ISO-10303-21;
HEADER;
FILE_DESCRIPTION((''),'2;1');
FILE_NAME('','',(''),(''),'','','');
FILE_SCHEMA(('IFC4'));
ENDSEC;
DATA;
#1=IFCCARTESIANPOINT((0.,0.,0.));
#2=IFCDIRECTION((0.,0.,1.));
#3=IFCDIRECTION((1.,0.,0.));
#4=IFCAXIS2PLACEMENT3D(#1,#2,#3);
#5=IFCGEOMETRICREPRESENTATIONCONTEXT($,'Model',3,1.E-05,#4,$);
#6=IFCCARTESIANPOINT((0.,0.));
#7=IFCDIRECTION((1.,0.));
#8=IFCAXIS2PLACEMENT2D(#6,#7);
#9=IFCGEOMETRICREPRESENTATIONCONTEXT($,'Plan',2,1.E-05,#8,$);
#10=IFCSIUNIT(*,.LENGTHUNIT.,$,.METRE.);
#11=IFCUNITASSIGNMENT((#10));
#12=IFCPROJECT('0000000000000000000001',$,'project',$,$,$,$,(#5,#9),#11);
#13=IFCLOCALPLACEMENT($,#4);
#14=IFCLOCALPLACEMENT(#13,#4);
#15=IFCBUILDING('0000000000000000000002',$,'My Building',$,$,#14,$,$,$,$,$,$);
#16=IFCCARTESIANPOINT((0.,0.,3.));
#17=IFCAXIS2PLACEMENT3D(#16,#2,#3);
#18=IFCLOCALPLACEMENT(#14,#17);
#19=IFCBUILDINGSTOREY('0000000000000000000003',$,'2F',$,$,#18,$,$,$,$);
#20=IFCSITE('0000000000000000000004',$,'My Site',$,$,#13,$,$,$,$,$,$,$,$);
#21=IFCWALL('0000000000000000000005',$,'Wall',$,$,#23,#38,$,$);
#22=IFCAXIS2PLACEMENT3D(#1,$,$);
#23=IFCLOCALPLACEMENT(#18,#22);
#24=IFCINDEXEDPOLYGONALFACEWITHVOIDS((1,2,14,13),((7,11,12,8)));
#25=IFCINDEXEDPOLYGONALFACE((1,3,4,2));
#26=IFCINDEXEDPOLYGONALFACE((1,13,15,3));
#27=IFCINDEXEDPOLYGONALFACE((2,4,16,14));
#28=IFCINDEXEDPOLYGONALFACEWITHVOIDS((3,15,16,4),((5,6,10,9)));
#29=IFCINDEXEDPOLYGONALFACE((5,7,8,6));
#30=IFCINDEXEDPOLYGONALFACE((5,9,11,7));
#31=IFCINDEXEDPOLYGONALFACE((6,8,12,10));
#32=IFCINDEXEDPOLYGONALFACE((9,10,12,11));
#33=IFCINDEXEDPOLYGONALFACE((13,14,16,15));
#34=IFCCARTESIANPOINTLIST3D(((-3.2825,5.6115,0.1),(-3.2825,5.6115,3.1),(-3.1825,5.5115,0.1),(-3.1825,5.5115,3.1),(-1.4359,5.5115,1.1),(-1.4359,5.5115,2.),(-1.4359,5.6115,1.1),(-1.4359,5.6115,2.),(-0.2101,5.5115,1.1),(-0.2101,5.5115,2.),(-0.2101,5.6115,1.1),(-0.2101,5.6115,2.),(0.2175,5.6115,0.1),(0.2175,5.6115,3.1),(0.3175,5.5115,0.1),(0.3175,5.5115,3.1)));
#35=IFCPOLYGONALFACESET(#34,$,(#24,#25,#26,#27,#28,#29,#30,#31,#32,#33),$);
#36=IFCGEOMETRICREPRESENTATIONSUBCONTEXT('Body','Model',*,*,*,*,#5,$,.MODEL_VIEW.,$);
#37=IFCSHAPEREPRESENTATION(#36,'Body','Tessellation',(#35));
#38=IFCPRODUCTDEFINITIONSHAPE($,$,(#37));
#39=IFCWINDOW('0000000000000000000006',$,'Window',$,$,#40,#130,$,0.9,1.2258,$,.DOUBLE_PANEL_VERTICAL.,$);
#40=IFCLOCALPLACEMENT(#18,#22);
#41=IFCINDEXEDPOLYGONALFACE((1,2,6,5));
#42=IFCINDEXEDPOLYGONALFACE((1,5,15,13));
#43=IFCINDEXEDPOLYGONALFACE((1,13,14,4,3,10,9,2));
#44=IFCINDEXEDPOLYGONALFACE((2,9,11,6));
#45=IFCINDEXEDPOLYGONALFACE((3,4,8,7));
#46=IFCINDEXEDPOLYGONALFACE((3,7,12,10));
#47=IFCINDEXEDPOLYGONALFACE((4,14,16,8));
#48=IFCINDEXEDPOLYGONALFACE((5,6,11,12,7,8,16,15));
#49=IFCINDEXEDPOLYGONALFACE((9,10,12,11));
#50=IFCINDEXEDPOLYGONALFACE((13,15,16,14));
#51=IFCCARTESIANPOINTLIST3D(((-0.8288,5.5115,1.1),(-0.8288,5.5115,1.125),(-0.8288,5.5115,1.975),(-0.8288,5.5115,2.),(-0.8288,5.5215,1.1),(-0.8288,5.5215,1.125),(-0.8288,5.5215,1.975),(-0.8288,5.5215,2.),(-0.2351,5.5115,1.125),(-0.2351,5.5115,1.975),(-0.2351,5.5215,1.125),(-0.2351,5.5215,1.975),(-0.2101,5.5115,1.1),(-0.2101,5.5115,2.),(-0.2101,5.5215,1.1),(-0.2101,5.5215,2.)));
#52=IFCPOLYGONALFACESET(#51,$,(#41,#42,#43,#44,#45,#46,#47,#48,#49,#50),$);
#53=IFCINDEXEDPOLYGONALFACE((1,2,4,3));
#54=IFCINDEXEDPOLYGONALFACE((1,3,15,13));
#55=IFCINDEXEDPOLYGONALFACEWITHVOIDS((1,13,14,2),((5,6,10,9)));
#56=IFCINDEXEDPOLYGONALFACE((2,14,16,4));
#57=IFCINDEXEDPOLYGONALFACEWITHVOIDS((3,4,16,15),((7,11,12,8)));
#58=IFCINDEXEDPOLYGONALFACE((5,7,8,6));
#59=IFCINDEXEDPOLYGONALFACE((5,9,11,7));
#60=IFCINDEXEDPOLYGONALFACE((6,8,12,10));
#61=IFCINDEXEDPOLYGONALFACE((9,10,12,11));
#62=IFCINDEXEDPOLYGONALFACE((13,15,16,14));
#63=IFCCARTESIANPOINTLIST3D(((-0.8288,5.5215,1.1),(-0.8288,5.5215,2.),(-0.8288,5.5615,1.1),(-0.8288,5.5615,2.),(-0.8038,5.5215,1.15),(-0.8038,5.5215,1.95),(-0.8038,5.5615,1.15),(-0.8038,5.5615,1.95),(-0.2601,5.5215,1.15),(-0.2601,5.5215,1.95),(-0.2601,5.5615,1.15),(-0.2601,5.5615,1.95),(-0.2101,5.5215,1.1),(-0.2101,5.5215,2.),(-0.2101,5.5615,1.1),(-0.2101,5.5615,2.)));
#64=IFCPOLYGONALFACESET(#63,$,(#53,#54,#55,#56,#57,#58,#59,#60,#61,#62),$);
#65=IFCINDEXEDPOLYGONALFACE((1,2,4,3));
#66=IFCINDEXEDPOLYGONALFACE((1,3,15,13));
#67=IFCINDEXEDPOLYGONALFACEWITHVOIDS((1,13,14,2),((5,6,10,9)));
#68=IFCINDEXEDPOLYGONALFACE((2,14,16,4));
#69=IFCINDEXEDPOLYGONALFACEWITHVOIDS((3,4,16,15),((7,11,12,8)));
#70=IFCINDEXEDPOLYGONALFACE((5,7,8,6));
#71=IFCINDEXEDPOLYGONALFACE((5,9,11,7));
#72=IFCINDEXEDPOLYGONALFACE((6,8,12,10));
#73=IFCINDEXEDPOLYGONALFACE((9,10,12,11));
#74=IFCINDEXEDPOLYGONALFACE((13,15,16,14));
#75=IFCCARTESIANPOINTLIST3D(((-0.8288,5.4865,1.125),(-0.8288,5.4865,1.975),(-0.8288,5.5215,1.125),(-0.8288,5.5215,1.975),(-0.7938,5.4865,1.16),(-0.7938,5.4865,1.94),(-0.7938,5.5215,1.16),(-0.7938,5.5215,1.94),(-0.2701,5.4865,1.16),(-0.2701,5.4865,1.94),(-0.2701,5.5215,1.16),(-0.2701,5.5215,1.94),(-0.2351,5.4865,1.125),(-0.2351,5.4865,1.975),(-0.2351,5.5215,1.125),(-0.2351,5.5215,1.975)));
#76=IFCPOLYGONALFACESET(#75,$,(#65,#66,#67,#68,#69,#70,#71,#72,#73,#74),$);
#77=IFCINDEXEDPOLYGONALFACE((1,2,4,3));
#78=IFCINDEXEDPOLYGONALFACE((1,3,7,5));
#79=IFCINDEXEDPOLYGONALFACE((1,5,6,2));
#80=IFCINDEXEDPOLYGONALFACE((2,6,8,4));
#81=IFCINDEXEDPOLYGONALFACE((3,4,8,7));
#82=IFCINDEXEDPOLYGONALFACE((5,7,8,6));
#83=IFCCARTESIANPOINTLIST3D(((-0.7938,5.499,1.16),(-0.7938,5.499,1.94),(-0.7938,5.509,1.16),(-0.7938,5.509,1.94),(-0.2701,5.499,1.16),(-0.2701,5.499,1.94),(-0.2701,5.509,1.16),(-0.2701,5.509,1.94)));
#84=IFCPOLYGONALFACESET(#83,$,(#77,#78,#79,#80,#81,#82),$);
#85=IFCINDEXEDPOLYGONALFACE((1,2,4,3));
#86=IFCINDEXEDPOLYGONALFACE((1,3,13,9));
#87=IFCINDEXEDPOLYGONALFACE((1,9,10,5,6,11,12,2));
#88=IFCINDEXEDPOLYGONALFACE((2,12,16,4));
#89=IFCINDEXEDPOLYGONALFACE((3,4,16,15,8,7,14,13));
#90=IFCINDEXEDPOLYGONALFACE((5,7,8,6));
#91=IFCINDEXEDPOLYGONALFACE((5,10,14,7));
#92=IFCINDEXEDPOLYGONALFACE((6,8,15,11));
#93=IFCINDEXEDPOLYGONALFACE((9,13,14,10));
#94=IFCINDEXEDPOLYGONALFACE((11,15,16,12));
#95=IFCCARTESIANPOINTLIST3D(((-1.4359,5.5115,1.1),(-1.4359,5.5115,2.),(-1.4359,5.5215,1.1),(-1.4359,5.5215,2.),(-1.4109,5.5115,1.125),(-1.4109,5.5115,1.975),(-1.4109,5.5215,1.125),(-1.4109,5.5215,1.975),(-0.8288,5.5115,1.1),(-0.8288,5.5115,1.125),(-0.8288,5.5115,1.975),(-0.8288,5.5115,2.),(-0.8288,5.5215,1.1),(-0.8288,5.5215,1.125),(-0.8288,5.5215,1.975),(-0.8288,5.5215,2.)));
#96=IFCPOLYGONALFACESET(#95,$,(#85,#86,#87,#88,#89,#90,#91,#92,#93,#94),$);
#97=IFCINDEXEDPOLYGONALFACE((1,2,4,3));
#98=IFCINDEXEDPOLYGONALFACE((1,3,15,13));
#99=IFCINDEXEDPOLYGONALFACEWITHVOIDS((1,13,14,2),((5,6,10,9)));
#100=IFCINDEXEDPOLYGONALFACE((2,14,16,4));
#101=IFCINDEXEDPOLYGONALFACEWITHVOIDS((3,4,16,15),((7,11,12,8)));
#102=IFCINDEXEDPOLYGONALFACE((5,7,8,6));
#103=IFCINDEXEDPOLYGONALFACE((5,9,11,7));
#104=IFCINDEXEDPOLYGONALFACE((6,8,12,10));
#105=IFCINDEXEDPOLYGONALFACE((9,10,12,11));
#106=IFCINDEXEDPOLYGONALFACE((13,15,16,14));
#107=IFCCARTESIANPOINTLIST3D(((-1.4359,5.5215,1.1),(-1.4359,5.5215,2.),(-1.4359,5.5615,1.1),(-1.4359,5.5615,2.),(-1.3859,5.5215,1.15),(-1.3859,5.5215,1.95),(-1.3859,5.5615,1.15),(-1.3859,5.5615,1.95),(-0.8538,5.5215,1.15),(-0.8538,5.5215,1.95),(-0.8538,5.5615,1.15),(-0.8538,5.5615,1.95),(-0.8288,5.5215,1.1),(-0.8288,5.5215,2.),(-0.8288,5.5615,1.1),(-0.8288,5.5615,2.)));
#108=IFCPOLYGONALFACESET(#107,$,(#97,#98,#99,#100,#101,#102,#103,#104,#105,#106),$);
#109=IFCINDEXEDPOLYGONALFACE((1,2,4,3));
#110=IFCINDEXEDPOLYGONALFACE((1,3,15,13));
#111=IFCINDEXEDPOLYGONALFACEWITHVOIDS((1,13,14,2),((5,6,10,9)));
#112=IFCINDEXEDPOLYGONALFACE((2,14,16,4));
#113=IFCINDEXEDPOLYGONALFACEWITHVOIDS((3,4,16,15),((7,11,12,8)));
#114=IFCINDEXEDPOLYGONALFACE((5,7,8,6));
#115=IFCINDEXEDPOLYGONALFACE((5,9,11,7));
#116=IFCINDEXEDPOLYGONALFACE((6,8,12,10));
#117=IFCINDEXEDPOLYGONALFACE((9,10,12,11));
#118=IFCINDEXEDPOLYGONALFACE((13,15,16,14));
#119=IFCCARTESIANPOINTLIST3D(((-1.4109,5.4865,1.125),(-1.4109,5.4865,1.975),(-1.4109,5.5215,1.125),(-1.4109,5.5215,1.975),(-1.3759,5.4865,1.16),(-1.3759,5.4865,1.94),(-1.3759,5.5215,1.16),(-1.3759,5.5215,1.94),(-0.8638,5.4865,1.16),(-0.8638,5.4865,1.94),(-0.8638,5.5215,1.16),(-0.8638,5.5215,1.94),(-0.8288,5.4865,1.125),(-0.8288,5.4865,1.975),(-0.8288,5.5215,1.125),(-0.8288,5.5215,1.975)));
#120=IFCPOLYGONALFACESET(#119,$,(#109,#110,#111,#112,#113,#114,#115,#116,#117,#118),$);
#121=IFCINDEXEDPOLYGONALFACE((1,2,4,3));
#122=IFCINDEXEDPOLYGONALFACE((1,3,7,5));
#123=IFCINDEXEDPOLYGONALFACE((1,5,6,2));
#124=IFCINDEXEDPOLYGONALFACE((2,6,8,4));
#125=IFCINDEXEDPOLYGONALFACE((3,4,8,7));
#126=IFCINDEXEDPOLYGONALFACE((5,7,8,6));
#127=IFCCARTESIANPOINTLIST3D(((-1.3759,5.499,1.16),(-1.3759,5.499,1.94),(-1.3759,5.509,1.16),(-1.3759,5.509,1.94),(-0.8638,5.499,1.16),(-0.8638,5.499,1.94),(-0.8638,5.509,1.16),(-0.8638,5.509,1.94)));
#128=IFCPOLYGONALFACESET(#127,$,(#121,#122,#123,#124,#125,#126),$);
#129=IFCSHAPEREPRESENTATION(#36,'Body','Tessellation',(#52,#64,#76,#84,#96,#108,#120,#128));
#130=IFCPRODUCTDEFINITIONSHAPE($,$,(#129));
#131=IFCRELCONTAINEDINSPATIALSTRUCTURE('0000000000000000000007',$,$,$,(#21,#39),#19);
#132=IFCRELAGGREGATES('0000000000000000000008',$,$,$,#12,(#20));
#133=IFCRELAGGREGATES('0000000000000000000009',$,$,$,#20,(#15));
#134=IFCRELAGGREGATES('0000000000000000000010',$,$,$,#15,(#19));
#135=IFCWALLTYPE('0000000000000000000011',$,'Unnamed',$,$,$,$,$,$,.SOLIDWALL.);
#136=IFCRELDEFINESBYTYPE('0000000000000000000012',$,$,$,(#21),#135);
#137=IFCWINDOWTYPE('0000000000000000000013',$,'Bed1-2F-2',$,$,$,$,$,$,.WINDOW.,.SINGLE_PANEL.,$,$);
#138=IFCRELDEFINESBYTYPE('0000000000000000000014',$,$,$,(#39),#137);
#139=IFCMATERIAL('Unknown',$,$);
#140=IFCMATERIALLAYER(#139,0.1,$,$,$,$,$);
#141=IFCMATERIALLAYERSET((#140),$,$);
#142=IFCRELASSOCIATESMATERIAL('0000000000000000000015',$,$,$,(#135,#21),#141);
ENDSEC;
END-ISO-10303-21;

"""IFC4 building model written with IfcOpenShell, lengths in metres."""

from ifc_helpers import new_model, entity, si_unit, frame, origin_with_axes, origin_2d_with_axis, place, context, subcontext, project, spatial, line, indexed_curve, outline, extrude, shape, source, transform, mapped, material, layer, layer_set, layer_usage, type_object, type_shapes, element, fill, save


model = new_model("IFC4")

# Units and contexts
model_context = context("Model", 3, precision=1e-05, world=origin_with_axes())
plan_context = context("Plan", 2, precision=1e-05, world=origin_2d_with_axis())
body_context_1 = subcontext(model_context, "Body", "Model", "MODEL_VIEW")
body_context_2 = subcontext(plan_context, "Body", "Plan", "PLAN_VIEW")
ifc_project = project(units=[si_unit("LENGTHUNIT", "METRE")], contexts=[model_context, plan_context])

# Site, building, storey
site_placement = place(None, origin_with_axes())
site = spatial("IfcSite", under=ifc_project, at=site_placement, Name="My Site")
building_placement = place(site_placement, origin_with_axes())
building = spatial("IfcBuilding", under=site, at=building_placement, Name="My Building")
storey_placement = place(building_placement, frame((0.0, 0.0, 3.0), z_axis=(0.0, 0.0, 1.0), x_axis=(1.0, 0.0, 0.0)))
storey = spatial("IfcBuildingStorey", under=building, at=storey_placement, Name="2F")

# Shared definitions
ifc_material = material(Name="Unknown")

# Shared definitions
ifc_layer_1 = layer(ifc_material, 0.1)
ifc_layer_set_1 = layer_set([ifc_layer_1])
wall_type = type_object("IfcWallType", Name="Unnamed", PredefinedType="SOLIDWALL", material=ifc_layer_set_1)

# Wall, opening, window
ifc_layer_usage_1 = layer_usage(ifc_layer_set_1, "AXIS2", "POSITIVE", 0.0)
wall_1_placement = place(storey_placement, frame((-3.1825, 5.5115, 0.1), z_axis=(0.0, 0.0, 1.0), x_axis=(1.0, 0.0, 0.0)))
wall_1 = element("IfcWall", 1, at=wall_1_placement, inside=storey, type_object=wall_type, material=ifc_layer_usage_1, Name="Wall", context=body_context_1, shape_type="SweptSolid", body=[
    extrude(outline(indexed_curve([(0.0, 0.0), (-0.1, 0.1), (3.4, 0.1), (3.5, 0.0)], segments=[line(1, 2, 3, 4, 1)])), origin_with_axes(), (0.0, 0.0, 1.0), 3.0),
])
shared_shape_1 = source(origin_with_axes(), body_context_1, "Body", "SweptSolid", [
    extrude(outline(indexed_curve([(0.0, 0.0), (1.2258, 0.0), (1.2258, 0.9), (0.0, 0.9)], segments=[line(1, 2, 3, 4, 1)])), frame((0.0, -0.6, 0.0), z_axis=(0.0, -1.0, 0.0), x_axis=(1.0, 0.0, 0.0)), (0.0, 0.0, -1.0), 1.2),
])
opening_1_placement = place(wall_1_placement, frame((2.9724, 0.1, 1.0), z_axis=(0.0, 0.0, 1.0), x_axis=(-1.0, 0.0, 0.0)))
opening_1 = element("IfcOpeningElement", 2, at=opening_1_placement, cuts=wall_1, PredefinedType="OPENING", context=body_context_1, shape_type="MappedRepresentation", body=[
    mapped(shared_shape_1, transform((0.0, 0.0, 0.0), x_axis=(1.0, 0.0, 0.0), y_axis=(0.0, 1.0, 0.0), z_axis=(0.0, 0.0, 1.0), scale=1.0)),
])
window_type_1 = type_object("IfcWindowType", Name="Bed1-2F-2", PartitioningType="SINGLE_PANEL", PredefinedType="WINDOW")
shared_shape_2 = source(origin_with_axes(), body_context_1, "Body", "SweptSolid", [
    extrude(outline(indexed_curve([(0.6187, 0.0), (0.0, 0.0), (0.0, 0.9), (0.6187, 0.9), (0.6187, 0.875), (0.025, 0.875), (0.025, 0.025), (0.6187, 0.025)], segments=[line(1, 2, 3, 4, 5, 6, 7, 8, 1)])), frame((0.0, 0.09, 0.0), z_axis=(0.0, -1.0, 0.0), x_axis=(1.0, 0.0, 0.0)), (0.0, 0.0, -1.0), 0.01),
    extrude(outline(indexed_curve([(0.0, 0.0), (0.6187, 0.0), (0.6187, 0.9), (0.0, 0.9)], segments=[line(1, 2, 3, 4, 1)]), holes=[indexed_curve([(0.05, 0.05), (0.5937, 0.05), (0.5937, 0.85), (0.05, 0.85)], segments=[line(1, 2, 3, 4, 1)])]), frame((0.0, 0.05, 0.0), z_axis=(0.0, -1.0, 0.0), x_axis=(1.0, 0.0, 0.0)), (0.0, 0.0, -1.0), 0.04),
    extrude(outline(indexed_curve([(0.0, 0.0), (0.5937, 0.0), (0.5937, 0.85), (0.0, 0.85)], segments=[line(1, 2, 3, 4, 1)]), holes=[indexed_curve([(0.035, 0.035), (0.5587, 0.035), (0.5587, 0.815), (0.035, 0.815)], segments=[line(1, 2, 3, 4, 1)])]), frame((0.025, 0.09, 0.025), z_axis=(0.0, -1.0, 0.0), x_axis=(1.0, 0.0, 0.0)), (0.0, 0.0, -1.0), 0.035),
    extrude(outline(indexed_curve([(0.035, 0.035), (0.5587, 0.035), (0.5587, 0.815), (0.035, 0.815)], segments=[line(1, 2, 3, 4, 1)])), frame((0.025, 0.1025, 0.025), z_axis=(0.0, -1.0, 0.0), x_axis=(1.0, 0.0, 0.0)), (0.0, 0.0, -1.0), 0.01),
    extrude(outline(indexed_curve([(0.0, 0.9), (0.6071, 0.9), (0.6071, 0.0), (0.0, 0.0), (0.0, 0.025), (0.5821, 0.025), (0.5821, 0.875), (0.0, 0.875)], segments=[line(1, 2, 3, 4, 5, 6, 7, 8, 1)])), frame((0.6187, 0.09, 0.0), z_axis=(0.0, -1.0, 0.0), x_axis=(1.0, 0.0, 0.0)), (0.0, 0.0, -1.0), 0.01),
    extrude(outline(indexed_curve([(0.0, 0.0), (0.6071, 0.0), (0.6071, 0.9), (0.0, 0.9)], segments=[line(1, 2, 3, 4, 1)]), holes=[indexed_curve([(0.025, 0.05), (0.5571, 0.05), (0.5571, 0.85), (0.025, 0.85)], segments=[line(1, 2, 3, 4, 1)])]), frame((0.6187, 0.05, 0.0), z_axis=(0.0, -1.0, 0.0), x_axis=(1.0, 0.0, 0.0)), (0.0, 0.0, -1.0), 0.04),
    extrude(outline(indexed_curve([(0.0, 0.0), (0.5821, 0.0), (0.5821, 0.85), (0.0, 0.85)], segments=[line(1, 2, 3, 4, 1)]), holes=[indexed_curve([(0.035, 0.035), (0.5471, 0.035), (0.5471, 0.815), (0.035, 0.815)], segments=[line(1, 2, 3, 4, 1)])]), frame((0.6187, 0.09, 0.025), z_axis=(0.0, -1.0, 0.0), x_axis=(1.0, 0.0, 0.0)), (0.0, 0.0, -1.0), 0.035),
    extrude(outline(indexed_curve([(0.035, 0.035), (0.5471, 0.035), (0.5471, 0.815), (0.035, 0.815)], segments=[line(1, 2, 3, 4, 1)])), frame((0.6187, 0.1025, 0.025), z_axis=(0.0, -1.0, 0.0), x_axis=(1.0, 0.0, 0.0)), (0.0, 0.0, -1.0), 0.01),
])
shared_shape_3 = source(origin_with_axes(), body_context_2, "Body", "Curve2D", [
    entity("IfcIndexedPolyCurve", entity("IfcCartesianPointList2D", [[0.05, 0.05], [0.5937, 0.05]])),
    entity("IfcIndexedPolyCurve", entity("IfcCartesianPointList2D", [[0.0, 0.1], [0.025, 0.1], [0.025, 0.09], [0.05, 0.09], [0.05, 0.05], [0.0, 0.05]]), [entity("IfcLineIndex", [1, 2, 3, 4, 5, 6, 1])]),
    entity("IfcIndexedPolyCurve", entity("IfcCartesianPointList2D", [[0.6187, 0.1], [0.6187, 0.1], [0.6187, 0.09], [0.5937, 0.09], [0.5937, 0.05], [0.6187, 0.05]])),
    entity("IfcIndexedPolyCurve", entity("IfcCartesianPointList2D", [[0.025, 0.09], [0.06, 0.09], [0.06, 0.125], [0.025, 0.125]]), [entity("IfcLineIndex", [1, 2, 3, 4, 1])]),
    entity("IfcIndexedPolyCurve", entity("IfcCartesianPointList2D", [[0.6187, 0.09], [0.5837, 0.09], [0.5837, 0.125], [0.6187, 0.125]]), [entity("IfcLineIndex", [1, 2, 3, 4, 1])]),
    entity("IfcIndexedPolyCurve", entity("IfcCartesianPointList2D", [[0.06, 0.09], [0.5837, 0.09]])),
    entity("IfcIndexedPolyCurve", entity("IfcCartesianPointList2D", [[0.06, 0.125], [0.5837, 0.125]])),
    entity("IfcIndexedPolyCurve", entity("IfcCartesianPointList2D", [[0.06, 0.1075], [0.5837, 0.1075]])),
    entity("IfcIndexedPolyCurve", entity("IfcCartesianPointList2D", [[0.6437, 0.05], [1.1758, 0.05]])),
    entity("IfcIndexedPolyCurve", entity("IfcCartesianPointList2D", [[0.6187, 0.1], [0.6187, 0.1], [0.6187, 0.09], [0.6437, 0.09], [0.6437, 0.05], [0.6187, 0.05]])),
    entity("IfcIndexedPolyCurve", entity("IfcCartesianPointList2D", [[1.2258, 0.1], [1.2008, 0.1], [1.2008, 0.09], [1.1758, 0.09], [1.1758, 0.05], [1.2258, 0.05]]), [entity("IfcLineIndex", [1, 2, 3, 4, 5, 6, 1])]),
    entity("IfcIndexedPolyCurve", entity("IfcCartesianPointList2D", [[0.6187, 0.09], [0.6537, 0.09], [0.6537, 0.125], [0.6187, 0.125]]), [entity("IfcLineIndex", [1, 2, 3, 4, 1])]),
    entity("IfcIndexedPolyCurve", entity("IfcCartesianPointList2D", [[1.2008, 0.09], [1.1658, 0.09], [1.1658, 0.125], [1.2008, 0.125]]), [entity("IfcLineIndex", [1, 2, 3, 4, 1])]),
    entity("IfcIndexedPolyCurve", entity("IfcCartesianPointList2D", [[0.6537, 0.09], [1.1658, 0.09]])),
    entity("IfcIndexedPolyCurve", entity("IfcCartesianPointList2D", [[0.6537, 0.125], [1.1658, 0.125]])),
    entity("IfcIndexedPolyCurve", entity("IfcCartesianPointList2D", [[0.6537, 0.1075], [1.1658, 0.1075]])),
])
type_shapes(window_type_1, [shared_shape_2, shared_shape_3])
window_1_placement = place(opening_1_placement, frame((0.0, 0.0, 0.0), z_axis=(0.0, 0.0, 1.0), x_axis=(1.0, 0.0, 0.0)))
window_1 = element("IfcWindow", 3, at=window_1_placement, inside=storey, type_object=window_type_1, Name="Window", OverallHeight=0.9, OverallWidth=1.2258, PartitioningType="DOUBLE_PANEL_VERTICAL", shapes=[
    shape(body_context_1, "Body", "MappedRepresentation", [mapped(shared_shape_2, transform((0.0, 0.0, 0.0), x_axis=(1.0, 0.0, 0.0), y_axis=(0.0, 1.0, 0.0), z_axis=(0.0, 0.0, 1.0), scale=1.0))]),
    shape(body_context_2, "Body", "MappedRepresentation", [mapped(shared_shape_3, transform((0.0, 0.0, 0.0), x_axis=(1.0, 0.0, 0.0), y_axis=(0.0, 1.0, 0.0), z_axis=(0.0, 0.0, 1.0), scale=1.0))]),
])
fill(opening_1, window_1)

save(model, "model.ifc")
